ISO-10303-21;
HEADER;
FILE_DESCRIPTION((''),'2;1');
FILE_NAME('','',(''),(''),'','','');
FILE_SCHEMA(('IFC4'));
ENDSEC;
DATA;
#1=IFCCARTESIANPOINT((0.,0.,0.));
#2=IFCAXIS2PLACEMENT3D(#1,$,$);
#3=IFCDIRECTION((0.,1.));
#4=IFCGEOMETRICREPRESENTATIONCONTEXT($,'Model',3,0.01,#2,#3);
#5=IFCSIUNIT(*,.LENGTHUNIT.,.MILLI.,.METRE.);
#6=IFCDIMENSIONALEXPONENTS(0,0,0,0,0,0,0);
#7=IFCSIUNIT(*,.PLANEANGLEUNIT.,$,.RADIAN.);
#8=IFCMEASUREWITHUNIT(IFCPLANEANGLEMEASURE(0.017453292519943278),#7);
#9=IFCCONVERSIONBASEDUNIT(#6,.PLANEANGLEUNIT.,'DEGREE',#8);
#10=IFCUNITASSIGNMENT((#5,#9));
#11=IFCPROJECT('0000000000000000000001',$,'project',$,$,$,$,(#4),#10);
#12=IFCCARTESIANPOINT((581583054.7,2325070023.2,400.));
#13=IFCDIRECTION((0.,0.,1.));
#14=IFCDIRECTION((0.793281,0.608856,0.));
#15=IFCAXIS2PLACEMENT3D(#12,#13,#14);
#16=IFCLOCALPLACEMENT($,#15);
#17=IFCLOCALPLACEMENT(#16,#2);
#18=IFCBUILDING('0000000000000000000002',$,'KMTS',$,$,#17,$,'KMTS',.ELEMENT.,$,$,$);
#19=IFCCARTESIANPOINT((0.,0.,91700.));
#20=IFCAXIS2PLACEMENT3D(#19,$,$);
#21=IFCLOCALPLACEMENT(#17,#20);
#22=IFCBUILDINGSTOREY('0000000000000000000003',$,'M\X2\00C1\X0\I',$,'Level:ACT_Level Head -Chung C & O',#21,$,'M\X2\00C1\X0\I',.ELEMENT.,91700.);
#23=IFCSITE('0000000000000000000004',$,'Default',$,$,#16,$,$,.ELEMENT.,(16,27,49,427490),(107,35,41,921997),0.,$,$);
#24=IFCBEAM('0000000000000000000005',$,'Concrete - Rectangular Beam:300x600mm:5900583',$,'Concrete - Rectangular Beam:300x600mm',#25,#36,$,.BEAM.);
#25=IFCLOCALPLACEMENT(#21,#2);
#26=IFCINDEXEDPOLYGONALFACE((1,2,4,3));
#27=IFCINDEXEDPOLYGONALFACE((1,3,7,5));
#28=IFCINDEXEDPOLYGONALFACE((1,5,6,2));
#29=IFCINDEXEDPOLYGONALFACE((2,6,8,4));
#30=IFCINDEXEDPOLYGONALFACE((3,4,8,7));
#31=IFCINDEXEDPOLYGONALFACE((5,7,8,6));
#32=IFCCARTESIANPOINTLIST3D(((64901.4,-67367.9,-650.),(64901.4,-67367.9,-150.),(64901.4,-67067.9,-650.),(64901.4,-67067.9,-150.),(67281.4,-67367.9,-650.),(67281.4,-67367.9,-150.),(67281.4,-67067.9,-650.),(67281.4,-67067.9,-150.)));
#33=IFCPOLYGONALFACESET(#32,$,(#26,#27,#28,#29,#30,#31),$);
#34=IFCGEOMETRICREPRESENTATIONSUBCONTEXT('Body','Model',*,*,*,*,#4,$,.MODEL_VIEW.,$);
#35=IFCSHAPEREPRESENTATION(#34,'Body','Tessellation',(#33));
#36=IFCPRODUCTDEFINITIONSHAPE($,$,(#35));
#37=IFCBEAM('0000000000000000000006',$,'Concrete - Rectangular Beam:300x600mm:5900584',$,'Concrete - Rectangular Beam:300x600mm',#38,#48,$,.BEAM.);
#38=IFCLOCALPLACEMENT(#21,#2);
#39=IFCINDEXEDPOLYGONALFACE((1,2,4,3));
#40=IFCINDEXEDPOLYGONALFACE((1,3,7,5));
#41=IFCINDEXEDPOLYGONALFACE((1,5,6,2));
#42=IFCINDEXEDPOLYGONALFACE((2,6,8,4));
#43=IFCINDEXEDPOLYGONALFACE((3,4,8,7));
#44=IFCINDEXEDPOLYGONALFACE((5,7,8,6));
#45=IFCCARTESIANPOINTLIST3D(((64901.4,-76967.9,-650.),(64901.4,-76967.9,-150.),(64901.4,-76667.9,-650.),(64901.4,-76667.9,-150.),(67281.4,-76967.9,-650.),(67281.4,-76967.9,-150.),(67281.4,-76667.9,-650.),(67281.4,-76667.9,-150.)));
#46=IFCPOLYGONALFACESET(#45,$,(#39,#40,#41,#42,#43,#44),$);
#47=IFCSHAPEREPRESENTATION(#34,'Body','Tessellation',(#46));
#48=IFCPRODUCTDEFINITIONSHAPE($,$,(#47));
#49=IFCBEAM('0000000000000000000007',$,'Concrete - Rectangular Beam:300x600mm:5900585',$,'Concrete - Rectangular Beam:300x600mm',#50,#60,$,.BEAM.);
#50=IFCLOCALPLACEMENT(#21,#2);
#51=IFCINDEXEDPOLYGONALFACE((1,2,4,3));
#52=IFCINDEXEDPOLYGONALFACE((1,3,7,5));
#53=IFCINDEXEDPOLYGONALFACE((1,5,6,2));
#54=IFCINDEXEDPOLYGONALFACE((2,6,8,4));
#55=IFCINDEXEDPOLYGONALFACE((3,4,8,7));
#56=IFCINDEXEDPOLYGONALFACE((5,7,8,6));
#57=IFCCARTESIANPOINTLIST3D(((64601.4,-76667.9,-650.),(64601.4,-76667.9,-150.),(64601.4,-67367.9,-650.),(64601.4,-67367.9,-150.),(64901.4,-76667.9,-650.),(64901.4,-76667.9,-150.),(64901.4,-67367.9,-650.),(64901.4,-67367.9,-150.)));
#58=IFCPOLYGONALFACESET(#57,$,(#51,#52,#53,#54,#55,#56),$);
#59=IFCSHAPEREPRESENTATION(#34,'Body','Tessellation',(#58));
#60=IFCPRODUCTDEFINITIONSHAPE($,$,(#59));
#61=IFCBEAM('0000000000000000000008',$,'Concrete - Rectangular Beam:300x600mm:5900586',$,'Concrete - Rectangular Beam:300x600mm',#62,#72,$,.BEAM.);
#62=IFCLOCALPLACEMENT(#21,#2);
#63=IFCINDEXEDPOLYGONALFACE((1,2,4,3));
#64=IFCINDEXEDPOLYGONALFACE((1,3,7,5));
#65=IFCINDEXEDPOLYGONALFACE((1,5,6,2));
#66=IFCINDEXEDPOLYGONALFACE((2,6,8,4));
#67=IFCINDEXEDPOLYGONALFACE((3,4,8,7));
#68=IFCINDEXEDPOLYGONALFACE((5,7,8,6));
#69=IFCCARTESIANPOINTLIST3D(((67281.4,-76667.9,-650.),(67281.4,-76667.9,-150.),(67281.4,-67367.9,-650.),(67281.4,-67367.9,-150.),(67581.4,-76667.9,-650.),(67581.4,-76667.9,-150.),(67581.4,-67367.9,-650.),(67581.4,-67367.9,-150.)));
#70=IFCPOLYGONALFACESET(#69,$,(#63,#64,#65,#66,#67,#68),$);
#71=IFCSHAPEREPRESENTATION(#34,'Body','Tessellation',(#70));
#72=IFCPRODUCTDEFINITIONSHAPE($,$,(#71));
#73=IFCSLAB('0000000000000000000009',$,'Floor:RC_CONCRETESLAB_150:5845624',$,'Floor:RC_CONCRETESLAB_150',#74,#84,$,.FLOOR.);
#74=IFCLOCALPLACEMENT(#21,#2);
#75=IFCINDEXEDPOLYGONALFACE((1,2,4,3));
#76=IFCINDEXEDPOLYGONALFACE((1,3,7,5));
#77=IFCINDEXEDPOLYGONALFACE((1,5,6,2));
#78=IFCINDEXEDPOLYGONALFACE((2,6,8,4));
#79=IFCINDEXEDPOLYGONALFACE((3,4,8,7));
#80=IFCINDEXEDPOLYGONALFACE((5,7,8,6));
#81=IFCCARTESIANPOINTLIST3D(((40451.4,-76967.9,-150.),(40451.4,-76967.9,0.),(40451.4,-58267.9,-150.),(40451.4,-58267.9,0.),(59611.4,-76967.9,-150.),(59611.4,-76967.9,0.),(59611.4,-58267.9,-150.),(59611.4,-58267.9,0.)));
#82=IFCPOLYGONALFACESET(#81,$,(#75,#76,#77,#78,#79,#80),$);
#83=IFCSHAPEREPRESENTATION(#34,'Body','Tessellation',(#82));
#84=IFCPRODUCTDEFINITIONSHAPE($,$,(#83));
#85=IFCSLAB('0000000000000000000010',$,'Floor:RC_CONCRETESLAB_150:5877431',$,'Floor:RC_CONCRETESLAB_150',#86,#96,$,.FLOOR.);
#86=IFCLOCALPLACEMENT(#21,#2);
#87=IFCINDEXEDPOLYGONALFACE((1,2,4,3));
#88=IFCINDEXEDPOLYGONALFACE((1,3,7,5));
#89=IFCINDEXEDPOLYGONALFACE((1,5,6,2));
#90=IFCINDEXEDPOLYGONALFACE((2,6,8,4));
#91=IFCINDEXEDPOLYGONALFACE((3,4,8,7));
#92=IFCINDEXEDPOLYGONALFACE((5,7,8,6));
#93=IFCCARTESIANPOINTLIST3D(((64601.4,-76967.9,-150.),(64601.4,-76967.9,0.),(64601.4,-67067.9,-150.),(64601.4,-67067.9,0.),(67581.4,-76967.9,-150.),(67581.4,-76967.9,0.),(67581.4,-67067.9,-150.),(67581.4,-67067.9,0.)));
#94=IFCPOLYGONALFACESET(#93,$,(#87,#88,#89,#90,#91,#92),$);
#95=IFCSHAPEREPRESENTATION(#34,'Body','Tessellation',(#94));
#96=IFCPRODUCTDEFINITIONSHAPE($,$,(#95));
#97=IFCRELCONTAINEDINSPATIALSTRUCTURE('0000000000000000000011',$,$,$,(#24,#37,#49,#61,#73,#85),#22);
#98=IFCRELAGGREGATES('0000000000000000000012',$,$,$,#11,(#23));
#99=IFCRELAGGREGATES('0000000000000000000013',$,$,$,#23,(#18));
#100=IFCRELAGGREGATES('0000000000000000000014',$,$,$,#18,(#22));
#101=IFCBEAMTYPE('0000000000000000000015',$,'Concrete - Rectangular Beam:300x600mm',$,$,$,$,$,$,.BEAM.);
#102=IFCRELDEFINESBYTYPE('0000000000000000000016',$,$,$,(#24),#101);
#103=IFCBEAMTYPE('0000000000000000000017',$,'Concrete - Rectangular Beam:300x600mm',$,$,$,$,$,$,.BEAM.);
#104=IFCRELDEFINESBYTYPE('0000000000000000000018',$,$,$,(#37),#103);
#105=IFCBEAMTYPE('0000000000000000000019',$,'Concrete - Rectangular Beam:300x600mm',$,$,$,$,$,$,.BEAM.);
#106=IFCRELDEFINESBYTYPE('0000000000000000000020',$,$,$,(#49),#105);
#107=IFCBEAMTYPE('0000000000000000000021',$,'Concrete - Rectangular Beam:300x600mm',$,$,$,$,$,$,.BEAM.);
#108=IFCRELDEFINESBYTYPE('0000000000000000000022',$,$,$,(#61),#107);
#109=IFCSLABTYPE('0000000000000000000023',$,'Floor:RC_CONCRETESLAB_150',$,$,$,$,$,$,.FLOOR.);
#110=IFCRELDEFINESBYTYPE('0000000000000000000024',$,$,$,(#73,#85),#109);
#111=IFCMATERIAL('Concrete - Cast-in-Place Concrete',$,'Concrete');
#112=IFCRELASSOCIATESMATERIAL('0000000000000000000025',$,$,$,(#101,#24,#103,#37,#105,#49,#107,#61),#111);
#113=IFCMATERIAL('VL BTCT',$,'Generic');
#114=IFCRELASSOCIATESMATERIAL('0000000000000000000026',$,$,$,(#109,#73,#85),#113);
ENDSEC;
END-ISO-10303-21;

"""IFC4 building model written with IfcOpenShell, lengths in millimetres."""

from ifc_helpers import new_model, entity, si_unit, converted_unit, direction, frame, origin, place, context, subcontext, project, spatial, indexed_curve, outline, extrude, source, transform, mapped, material, type_object, type_shapes, element, save


model = new_model("IFC4")

# Units and contexts
model_context = context("Model", 3, precision=0.01, world=origin(), true_north=direction((0.0, 1.0)))
body_context = subcontext(model_context, "Body", "Model", "MODEL_VIEW")
ifc_project = project(units=[si_unit("LENGTHUNIT", "METRE", prefix="MILLI"), converted_unit("PLANEANGLEUNIT", "DEGREE", entity("IfcPlaneAngleMeasure", 0.017453292519943278), si_unit("PLANEANGLEUNIT", "RADIAN"), dimensions=[0, 0, 0, 0, 0, 0, 0])], contexts=[model_context])

# Site, building, storey
site_placement = place(None, frame((581583054.7, 2325070023.2, 400.0), z_axis=(0.0, 0.0, 1.0), x_axis=(0.793281, 0.608856, 0.0)))
site = spatial("IfcSite", under=ifc_project, at=site_placement, Name="Default", CompositionType="ELEMENT", RefLatitude=(16, 27, 49, 427490), RefLongitude=(107, 35, 41, 921997), RefElevation=0.0)
building_placement = place(site_placement, origin())
building = spatial("IfcBuilding", under=site, at=building_placement, Name="KMTS", LongName="KMTS", CompositionType="ELEMENT")
storey_placement = place(building_placement, frame((0.0, 0.0, 91700.0)))
storey = spatial("IfcBuildingStorey", under=building, at=storey_placement, Name="MÁI", ObjectType="Level:ACT_Level Head -Chung C & O", LongName="MÁI", CompositionType="ELEMENT", Elevation=91700.0)

# Beams
ifc_material_1 = material(Name="Concrete - Cast-in-Place Concrete", Category="Concrete")
beam_type_1 = type_object("IfcBeamType", Name="Concrete - Rectangular Beam:300x600mm", PredefinedType="BEAM", material=ifc_material_1)
shared_shape_1 = source(origin(), body_context, "Body", "SweptSolid", [
    extrude(outline(indexed_curve([(-250.0, -150.0), (250.0, -150.0), (250.0, 150.0), (-250.0, 150.0), (-250.0, -150.0)], self_intersect=False)), frame((64901.4, -67217.9, 91300.0), z_axis=(1.0, 0.0, 0.0), x_axis=(0.0, 0.0, -1.0)), (0.0, 0.0, 1.0), 2380.0),
])
type_shapes(beam_type_1, [shared_shape_1])
beam_1_placement = place(storey_placement, frame((0.0, 0.0, -91700.0)))
element("IfcBeam", 1, at=beam_1_placement, inside=storey, type_object=beam_type_1, material=ifc_material_1, Name="Concrete - Rectangular Beam:300x600mm:5900583", ObjectType="Concrete - Rectangular Beam:300x600mm", PredefinedType="BEAM", context=body_context, shape_type="MappedRepresentation", body=[
    mapped(shared_shape_1, transform((0.0, 0.0, 0.0), scale=1.0)),
])
beam_type_2 = type_object("IfcBeamType", Name="Concrete - Rectangular Beam:300x600mm", PredefinedType="BEAM", material=ifc_material_1)
shared_shape_2 = source(origin(), body_context, "Body", "SweptSolid", [
    extrude(outline(indexed_curve([(-250.0, -150.0), (250.0, -150.0), (250.0, 150.0), (-250.0, 150.0), (-250.0, -150.0)], self_intersect=False)), frame((67281.4, -76817.9, 91300.0), z_axis=(-1.0, 0.0, 0.0), x_axis=(0.0, 0.0, -1.0)), (0.0, 0.0, 1.0), 2380.0),
])
type_shapes(beam_type_2, [shared_shape_2])
beam_2_placement = place(storey_placement, frame((0.0, 0.0, -91700.0)))
element("IfcBeam", 2, at=beam_2_placement, inside=storey, type_object=beam_type_2, material=ifc_material_1, Name="Concrete - Rectangular Beam:300x600mm:5900584", ObjectType="Concrete - Rectangular Beam:300x600mm", PredefinedType="BEAM", context=body_context, shape_type="MappedRepresentation", body=[
    mapped(shared_shape_2, transform((0.0, 0.0, 0.0), scale=1.0)),
])
beam_type_3 = type_object("IfcBeamType", Name="Concrete - Rectangular Beam:300x600mm", PredefinedType="BEAM", material=ifc_material_1)
shared_shape_3 = source(origin(), body_context, "Body", "SweptSolid", [
    extrude(outline(indexed_curve([(-150.0, -250.0), (150.0, -250.0), (150.0, 250.0), (-150.0, 250.0), (-150.0, -250.0)], self_intersect=False)), frame((64751.4, -76667.9, 91300.0), z_axis=(0.0, 1.0, 0.0), x_axis=(-1.0, 0.0, 0.0)), (0.0, 0.0, 1.0), 9300.0),
])
type_shapes(beam_type_3, [shared_shape_3])
beam_3_placement = place(storey_placement, frame((0.0, 0.0, -91700.0)))
element("IfcBeam", 3, at=beam_3_placement, inside=storey, type_object=beam_type_3, material=ifc_material_1, Name="Concrete - Rectangular Beam:300x600mm:5900585", ObjectType="Concrete - Rectangular Beam:300x600mm", PredefinedType="BEAM", context=body_context, shape_type="MappedRepresentation", body=[
    mapped(shared_shape_3, transform((0.0, 0.0, 0.0), scale=1.0)),
])
beam_type_4 = type_object("IfcBeamType", Name="Concrete - Rectangular Beam:300x600mm", PredefinedType="BEAM", material=ifc_material_1)
shared_shape_4 = source(origin(), body_context, "Body", "SweptSolid", [
    extrude(outline(indexed_curve([(-150.0, -250.0), (150.0, -250.0), (150.0, 250.0), (-150.0, 250.0), (-150.0, -250.0)], self_intersect=False)), frame((67431.4, -67367.9, 91300.0), z_axis=(0.0, -1.0, 0.0), x_axis=(-1.0, 0.0, 0.0)), (0.0, 0.0, 1.0), 9300.0),
])
type_shapes(beam_type_4, [shared_shape_4])
beam_4_placement = place(storey_placement, frame((0.0, 0.0, -91700.0)))
element("IfcBeam", 4, at=beam_4_placement, inside=storey, type_object=beam_type_4, material=ifc_material_1, Name="Concrete - Rectangular Beam:300x600mm:5900586", ObjectType="Concrete - Rectangular Beam:300x600mm", PredefinedType="BEAM", context=body_context, shape_type="MappedRepresentation", body=[
    mapped(shared_shape_4, transform((0.0, 0.0, 0.0), scale=1.0)),
])

# Slabs
ifc_material_2 = material(Name="VL BTCT", Category="Generic")
slab_type = type_object("IfcSlabType", Name="Floor:RC_CONCRETESLAB_150", PredefinedType="FLOOR", material=ifc_material_2)
slab_1_placement = place(storey_placement, origin())
element("IfcSlab", 5, at=slab_1_placement, inside=storey, type_object=slab_type, material=ifc_material_2, Name="Floor:RC_CONCRETESLAB_150:5845624", ObjectType="Floor:RC_CONCRETESLAB_150", PredefinedType="FLOOR", context=body_context, shape_type="SweptSolid", body=[
    extrude(outline(indexed_curve([(-9350.0, -9580.0), (9350.0, -9580.0), (9350.0, 9580.0), (-9350.0, 9580.0), (-9350.0, -9580.0)], self_intersect=False)), frame((50031.4, -67617.9, 0.0), z_axis=(0.0, 0.0, -1.0), x_axis=(0.0, 1.0, 0.0)), (0.0, 0.0, 1.0), 150.0),
])
slab_2_placement = place(storey_placement, origin())
element("IfcSlab", 6, at=slab_2_placement, inside=storey, type_object=slab_type, material=ifc_material_2, Name="Floor:RC_CONCRETESLAB_150:5877431", ObjectType="Floor:RC_CONCRETESLAB_150", PredefinedType="FLOOR", context=body_context, shape_type="SweptSolid", body=[
    extrude(outline(indexed_curve([(-4950.0, -1490.0), (4950.0, -1490.0), (4950.0, 1490.0), (-4950.0, 1490.0), (-4950.0, -1490.0)], self_intersect=False)), frame((66091.4, -72017.9, 0.0), z_axis=(0.0, 0.0, -1.0), x_axis=(0.0, 1.0, 0.0)), (0.0, 0.0, 1.0), 150.0),
])

save(model, "model.ifc")
